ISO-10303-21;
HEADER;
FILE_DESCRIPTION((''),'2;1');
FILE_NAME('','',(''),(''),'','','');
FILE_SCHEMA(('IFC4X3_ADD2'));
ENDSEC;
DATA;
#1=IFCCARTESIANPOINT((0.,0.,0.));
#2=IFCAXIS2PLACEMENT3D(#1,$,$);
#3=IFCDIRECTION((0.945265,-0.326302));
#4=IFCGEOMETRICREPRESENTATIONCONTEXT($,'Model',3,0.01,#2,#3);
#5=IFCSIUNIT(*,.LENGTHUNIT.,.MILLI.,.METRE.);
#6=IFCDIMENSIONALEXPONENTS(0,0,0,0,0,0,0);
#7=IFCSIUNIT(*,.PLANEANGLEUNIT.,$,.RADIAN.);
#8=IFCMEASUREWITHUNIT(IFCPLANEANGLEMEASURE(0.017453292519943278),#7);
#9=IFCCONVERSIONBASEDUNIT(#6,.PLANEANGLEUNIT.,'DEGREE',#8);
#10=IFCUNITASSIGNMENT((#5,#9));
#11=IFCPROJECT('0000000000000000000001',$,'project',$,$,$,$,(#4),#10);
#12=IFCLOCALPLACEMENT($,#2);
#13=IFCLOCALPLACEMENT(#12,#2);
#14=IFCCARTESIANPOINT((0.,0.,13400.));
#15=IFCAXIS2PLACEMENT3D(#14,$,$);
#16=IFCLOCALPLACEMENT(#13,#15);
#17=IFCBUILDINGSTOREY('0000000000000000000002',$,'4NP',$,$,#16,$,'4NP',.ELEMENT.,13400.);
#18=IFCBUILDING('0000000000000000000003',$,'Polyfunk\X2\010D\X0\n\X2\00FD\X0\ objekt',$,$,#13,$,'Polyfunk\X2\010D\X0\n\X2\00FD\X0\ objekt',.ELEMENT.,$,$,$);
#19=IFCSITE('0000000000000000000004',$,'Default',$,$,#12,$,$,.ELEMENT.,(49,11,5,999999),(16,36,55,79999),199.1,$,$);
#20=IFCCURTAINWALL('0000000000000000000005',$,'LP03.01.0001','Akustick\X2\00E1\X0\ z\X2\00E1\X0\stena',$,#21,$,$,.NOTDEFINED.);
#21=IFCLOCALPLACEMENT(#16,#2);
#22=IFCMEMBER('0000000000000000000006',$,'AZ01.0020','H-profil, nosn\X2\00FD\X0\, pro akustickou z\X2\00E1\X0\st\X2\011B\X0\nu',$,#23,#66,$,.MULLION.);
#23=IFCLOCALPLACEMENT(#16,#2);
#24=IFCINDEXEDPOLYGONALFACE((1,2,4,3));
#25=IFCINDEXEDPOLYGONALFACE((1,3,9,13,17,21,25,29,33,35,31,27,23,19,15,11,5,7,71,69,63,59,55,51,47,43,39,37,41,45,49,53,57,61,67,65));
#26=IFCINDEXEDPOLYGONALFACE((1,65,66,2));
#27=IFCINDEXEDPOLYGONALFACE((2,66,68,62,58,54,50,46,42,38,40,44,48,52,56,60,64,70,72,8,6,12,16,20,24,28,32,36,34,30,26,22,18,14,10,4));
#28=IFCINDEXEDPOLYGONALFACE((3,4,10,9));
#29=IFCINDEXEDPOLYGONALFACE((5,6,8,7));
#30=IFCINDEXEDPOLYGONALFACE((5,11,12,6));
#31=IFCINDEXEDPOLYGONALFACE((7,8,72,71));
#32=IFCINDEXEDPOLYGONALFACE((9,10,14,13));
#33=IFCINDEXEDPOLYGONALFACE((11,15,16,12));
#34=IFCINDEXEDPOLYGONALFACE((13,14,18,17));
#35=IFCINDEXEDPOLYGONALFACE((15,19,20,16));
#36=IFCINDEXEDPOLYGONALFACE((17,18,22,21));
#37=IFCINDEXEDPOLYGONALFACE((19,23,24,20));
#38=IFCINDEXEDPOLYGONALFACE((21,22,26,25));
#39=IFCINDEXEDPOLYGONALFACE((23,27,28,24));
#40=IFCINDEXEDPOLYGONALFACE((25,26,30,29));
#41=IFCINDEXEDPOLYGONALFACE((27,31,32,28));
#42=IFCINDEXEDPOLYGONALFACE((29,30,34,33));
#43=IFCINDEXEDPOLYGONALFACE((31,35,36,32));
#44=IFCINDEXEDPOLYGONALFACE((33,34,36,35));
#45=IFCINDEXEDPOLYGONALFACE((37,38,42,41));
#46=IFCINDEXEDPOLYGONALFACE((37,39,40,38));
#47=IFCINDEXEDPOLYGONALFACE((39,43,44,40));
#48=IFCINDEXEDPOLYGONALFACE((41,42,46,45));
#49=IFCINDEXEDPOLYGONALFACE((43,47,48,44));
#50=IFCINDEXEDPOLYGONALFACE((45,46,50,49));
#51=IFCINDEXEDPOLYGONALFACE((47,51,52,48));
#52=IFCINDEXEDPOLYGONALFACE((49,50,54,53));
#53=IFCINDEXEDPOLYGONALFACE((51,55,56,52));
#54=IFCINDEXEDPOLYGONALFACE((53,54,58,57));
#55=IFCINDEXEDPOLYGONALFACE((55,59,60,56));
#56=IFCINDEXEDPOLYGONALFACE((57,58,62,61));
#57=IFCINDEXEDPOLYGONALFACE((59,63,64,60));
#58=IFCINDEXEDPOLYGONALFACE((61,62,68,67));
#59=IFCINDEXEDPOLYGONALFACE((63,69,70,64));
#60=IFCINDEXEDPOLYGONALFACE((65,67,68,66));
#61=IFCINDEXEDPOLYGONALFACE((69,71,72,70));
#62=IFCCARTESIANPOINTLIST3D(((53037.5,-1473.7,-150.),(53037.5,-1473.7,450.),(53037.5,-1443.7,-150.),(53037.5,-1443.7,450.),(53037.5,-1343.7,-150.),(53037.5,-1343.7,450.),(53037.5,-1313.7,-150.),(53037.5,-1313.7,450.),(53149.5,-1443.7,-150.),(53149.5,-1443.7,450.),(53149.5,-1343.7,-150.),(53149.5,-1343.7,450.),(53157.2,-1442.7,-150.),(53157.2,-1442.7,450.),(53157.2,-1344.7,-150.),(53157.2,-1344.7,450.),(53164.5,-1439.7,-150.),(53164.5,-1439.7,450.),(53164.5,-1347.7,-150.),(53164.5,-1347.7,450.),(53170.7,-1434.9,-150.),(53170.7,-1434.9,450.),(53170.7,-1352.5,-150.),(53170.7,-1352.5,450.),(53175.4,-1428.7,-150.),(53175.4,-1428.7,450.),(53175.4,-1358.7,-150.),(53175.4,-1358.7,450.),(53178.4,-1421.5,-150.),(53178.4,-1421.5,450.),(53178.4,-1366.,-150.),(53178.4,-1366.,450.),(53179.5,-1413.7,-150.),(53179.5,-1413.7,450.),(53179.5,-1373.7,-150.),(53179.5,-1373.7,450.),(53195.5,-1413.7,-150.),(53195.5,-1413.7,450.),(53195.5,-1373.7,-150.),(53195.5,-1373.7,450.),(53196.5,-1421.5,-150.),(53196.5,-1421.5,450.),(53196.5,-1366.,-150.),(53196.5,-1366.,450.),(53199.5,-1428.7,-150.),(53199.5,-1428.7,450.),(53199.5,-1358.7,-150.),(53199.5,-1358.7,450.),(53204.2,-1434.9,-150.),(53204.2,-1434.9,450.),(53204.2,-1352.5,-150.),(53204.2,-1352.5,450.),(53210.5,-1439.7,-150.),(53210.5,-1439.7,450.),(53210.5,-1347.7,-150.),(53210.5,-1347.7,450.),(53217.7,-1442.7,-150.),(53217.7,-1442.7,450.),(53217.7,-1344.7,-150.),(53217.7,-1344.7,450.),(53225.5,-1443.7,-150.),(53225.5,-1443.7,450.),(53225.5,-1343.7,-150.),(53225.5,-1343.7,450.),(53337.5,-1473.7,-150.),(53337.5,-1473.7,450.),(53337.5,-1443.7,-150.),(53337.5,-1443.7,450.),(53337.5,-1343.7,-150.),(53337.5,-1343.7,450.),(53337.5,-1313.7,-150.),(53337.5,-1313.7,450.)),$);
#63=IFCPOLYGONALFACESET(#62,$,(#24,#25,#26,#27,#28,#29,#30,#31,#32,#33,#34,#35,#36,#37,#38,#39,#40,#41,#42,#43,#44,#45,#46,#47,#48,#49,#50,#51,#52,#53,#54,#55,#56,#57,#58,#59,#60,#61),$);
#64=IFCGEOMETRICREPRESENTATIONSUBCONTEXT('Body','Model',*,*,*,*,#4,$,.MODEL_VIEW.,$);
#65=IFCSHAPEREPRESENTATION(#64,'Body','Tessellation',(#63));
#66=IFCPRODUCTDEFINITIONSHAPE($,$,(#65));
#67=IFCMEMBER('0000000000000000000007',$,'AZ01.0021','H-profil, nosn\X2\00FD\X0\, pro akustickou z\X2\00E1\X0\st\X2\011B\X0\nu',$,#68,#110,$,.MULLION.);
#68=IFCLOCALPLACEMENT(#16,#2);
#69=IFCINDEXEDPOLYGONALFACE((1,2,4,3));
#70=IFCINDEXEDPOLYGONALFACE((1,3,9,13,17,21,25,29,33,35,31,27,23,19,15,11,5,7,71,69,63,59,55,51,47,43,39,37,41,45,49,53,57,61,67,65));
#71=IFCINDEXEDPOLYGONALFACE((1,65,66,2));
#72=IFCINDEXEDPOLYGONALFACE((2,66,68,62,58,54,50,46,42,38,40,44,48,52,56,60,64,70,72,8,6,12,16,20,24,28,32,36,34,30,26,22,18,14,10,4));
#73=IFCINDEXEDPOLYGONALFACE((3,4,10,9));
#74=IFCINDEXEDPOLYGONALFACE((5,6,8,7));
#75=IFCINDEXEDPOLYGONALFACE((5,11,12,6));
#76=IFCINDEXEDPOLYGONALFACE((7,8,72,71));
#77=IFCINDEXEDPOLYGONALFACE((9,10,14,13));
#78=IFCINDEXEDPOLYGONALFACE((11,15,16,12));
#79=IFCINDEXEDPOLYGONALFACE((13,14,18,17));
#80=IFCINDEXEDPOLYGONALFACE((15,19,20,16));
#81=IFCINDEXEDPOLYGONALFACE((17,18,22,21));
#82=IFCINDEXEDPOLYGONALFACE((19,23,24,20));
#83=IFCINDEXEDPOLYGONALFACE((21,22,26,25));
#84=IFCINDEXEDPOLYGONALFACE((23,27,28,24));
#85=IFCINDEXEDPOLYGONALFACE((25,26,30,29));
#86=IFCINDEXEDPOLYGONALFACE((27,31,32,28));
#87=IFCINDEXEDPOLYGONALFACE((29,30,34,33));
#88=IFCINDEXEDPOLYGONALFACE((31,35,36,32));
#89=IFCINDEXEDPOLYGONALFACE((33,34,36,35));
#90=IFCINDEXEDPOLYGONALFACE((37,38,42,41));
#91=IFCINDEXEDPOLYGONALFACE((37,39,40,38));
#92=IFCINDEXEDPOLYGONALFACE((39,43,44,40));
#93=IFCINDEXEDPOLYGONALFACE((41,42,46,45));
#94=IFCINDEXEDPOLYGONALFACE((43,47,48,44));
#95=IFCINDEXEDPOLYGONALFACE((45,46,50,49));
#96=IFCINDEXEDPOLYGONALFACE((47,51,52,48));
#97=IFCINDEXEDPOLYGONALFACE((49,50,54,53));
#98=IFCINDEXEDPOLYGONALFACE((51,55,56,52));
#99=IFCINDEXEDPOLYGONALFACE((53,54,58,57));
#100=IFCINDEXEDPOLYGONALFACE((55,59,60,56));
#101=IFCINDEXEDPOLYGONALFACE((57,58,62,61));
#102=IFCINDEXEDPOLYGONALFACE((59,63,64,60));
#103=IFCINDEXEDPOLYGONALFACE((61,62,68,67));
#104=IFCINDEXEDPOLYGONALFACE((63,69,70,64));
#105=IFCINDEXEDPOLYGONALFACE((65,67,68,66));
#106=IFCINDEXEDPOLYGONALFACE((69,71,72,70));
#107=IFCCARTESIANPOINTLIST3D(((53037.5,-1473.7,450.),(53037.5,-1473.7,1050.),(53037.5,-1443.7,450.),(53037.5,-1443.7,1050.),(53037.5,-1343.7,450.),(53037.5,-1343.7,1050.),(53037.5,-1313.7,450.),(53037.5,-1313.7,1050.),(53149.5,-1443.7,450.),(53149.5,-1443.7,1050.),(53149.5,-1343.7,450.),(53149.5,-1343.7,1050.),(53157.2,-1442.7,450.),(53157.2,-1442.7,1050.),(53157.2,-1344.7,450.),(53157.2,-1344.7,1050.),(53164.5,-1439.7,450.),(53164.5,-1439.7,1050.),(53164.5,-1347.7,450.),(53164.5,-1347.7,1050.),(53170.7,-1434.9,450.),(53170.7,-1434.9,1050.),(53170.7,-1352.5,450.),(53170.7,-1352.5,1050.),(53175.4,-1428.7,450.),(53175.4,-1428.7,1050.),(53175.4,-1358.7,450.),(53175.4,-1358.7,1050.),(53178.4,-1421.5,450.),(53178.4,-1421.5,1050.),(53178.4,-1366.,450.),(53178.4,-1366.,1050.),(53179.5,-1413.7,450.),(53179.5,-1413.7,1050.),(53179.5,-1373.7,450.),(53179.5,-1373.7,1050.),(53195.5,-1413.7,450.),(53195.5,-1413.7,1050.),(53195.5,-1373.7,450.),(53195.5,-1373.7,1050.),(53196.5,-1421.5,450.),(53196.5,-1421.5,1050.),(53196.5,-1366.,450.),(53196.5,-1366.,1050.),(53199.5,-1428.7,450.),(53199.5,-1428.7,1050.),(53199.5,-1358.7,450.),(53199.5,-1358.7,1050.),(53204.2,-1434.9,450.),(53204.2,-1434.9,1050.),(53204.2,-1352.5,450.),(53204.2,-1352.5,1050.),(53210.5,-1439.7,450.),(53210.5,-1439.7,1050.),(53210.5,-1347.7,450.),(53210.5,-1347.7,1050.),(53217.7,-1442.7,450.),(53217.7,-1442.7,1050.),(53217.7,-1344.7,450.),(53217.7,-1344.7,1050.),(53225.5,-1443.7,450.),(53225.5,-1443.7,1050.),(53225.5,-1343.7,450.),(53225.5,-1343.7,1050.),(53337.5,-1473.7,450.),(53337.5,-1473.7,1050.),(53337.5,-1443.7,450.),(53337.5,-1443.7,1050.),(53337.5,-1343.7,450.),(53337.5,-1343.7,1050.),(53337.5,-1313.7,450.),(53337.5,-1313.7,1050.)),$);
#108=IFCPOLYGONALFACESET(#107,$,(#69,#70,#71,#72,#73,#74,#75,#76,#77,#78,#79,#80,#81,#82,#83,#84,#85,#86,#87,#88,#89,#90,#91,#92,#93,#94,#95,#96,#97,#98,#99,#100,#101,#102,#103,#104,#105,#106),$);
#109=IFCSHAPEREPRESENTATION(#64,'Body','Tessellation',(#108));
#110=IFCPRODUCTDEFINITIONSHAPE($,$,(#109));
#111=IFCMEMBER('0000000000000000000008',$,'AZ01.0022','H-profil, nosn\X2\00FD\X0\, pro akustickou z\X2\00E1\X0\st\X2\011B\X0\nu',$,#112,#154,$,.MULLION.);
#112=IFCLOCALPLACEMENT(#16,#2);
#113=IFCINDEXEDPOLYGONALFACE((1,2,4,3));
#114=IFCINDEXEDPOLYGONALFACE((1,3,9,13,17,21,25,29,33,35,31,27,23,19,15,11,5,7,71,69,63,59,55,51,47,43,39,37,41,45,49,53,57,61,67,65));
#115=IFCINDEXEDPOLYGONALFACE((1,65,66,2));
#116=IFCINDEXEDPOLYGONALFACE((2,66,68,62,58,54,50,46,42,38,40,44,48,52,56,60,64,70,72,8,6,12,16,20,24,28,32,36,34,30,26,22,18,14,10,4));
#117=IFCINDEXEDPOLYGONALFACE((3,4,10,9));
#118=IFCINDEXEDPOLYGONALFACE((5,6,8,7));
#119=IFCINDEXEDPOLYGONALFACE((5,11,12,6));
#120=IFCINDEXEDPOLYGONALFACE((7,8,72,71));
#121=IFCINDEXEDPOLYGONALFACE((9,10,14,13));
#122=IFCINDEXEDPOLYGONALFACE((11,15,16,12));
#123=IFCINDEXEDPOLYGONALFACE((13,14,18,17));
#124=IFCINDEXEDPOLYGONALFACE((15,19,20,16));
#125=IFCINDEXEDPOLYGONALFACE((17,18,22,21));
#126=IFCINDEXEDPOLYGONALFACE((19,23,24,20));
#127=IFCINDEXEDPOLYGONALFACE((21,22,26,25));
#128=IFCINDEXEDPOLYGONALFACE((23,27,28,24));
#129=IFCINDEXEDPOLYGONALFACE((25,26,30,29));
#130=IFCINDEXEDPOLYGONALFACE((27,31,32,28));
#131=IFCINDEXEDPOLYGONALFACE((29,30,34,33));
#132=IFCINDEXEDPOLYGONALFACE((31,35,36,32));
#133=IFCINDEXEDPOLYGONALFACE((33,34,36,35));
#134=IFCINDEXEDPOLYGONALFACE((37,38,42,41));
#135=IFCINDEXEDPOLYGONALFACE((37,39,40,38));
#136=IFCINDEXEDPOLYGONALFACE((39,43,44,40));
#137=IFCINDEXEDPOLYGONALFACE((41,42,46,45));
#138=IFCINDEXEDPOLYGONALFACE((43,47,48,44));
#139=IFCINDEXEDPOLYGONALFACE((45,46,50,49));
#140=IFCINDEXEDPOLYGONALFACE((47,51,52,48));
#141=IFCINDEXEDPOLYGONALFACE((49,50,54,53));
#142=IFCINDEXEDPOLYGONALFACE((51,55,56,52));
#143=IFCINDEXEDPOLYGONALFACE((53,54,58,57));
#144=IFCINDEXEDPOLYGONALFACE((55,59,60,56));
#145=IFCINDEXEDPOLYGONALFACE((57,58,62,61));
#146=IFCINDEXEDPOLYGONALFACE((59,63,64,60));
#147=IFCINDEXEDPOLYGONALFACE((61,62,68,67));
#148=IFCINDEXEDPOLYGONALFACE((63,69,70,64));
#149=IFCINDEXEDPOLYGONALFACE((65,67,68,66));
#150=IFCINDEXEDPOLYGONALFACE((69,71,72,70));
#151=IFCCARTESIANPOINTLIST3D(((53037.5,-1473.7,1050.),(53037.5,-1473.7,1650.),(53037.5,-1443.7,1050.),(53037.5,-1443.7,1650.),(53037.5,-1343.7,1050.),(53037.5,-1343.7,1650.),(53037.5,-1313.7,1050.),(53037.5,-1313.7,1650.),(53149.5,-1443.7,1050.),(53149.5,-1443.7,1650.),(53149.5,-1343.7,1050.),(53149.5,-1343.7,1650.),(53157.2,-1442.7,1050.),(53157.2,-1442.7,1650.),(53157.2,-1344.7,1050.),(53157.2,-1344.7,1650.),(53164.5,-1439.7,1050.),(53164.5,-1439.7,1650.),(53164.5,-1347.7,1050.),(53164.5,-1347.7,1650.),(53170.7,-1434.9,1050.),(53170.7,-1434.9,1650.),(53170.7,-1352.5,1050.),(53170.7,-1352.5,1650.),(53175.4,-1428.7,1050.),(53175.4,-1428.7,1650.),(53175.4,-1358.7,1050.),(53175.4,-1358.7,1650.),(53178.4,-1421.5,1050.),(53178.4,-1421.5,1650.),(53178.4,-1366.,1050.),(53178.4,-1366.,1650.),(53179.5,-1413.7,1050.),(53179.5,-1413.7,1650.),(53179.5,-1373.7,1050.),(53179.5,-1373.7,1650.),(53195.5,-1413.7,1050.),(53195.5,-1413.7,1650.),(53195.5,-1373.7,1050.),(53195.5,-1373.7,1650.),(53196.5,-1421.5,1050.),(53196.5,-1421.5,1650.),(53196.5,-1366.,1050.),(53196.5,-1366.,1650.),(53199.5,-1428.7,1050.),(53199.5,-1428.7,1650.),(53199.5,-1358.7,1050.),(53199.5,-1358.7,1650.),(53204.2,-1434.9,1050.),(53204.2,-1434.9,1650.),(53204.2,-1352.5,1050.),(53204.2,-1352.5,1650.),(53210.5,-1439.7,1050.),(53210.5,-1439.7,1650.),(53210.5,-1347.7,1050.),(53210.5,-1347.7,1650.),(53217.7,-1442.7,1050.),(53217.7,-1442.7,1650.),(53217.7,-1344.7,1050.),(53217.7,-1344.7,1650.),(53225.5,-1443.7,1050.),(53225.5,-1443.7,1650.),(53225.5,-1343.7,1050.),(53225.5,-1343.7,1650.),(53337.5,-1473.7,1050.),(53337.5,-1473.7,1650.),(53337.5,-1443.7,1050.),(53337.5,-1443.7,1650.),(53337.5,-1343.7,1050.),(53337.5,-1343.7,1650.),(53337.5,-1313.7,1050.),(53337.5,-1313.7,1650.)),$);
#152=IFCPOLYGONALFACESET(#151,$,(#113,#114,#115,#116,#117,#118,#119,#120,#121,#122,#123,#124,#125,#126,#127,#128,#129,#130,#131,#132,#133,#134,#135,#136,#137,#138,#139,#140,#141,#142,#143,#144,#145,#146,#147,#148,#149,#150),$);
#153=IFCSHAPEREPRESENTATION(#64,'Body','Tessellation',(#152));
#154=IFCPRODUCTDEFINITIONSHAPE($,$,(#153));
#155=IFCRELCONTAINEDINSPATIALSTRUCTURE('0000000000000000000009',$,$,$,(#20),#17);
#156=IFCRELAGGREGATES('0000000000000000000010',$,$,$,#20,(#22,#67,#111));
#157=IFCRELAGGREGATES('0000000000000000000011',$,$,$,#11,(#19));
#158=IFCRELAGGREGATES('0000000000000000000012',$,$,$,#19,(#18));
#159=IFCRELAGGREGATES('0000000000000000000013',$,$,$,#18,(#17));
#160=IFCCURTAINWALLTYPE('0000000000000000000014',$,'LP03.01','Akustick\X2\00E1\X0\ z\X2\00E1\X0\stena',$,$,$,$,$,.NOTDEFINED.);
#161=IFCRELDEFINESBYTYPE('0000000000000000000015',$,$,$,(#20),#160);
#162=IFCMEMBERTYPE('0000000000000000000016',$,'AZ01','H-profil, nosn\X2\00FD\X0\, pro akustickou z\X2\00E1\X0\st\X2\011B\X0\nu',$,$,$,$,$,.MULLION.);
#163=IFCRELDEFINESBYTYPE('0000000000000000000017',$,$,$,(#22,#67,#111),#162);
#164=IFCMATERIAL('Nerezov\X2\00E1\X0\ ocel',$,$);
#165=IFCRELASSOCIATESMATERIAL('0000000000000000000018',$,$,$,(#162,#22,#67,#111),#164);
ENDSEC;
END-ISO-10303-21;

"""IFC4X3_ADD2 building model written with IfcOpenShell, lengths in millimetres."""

from ifc_helpers import new_model, entity, si_unit, converted_unit, direction, frame, frame_2d, origin, place, context, subcontext, project, spatial, polyline, circle_curve, parameter, trimmed, segment, composite_curve, outline, extrude, source, transform, mapped, material, material_profile, profile_set, profile_usage, type_object, element, aggregate, save


model = new_model("IFC4X3_ADD2")

# Units and contexts
model_context = context("Model", 3, precision=0.01, world=origin(), true_north=direction((0.945265, -0.326302)))
body_context = subcontext(model_context, "Body", "Model", "MODEL_VIEW")
ifc_project = project(units=[si_unit("LENGTHUNIT", "METRE", prefix="MILLI"), converted_unit("PLANEANGLEUNIT", "DEGREE", entity("IfcPlaneAngleMeasure", 0.017453292519943278), si_unit("PLANEANGLEUNIT", "RADIAN"), dimensions=[0, 0, 0, 0, 0, 0, 0])], contexts=[model_context])

# Site, building, storey
site_placement = place(None, origin())
site = spatial("IfcSite", under=ifc_project, at=site_placement, Name="Default", CompositionType="ELEMENT", RefLatitude=(49, 11, 5, 999999), RefLongitude=(16, 36, 55, 79999), RefElevation=199.1)
building_placement = place(site_placement, origin())
building = spatial("IfcBuilding", under=site, at=building_placement, Name="Polyfunkčný objekt", LongName="Polyfunkčný objekt", CompositionType="ELEMENT")
storey_placement = place(building_placement, frame((0.0, 0.0, 13400.0)))
storey = spatial("IfcBuildingStorey", under=building, at=storey_placement, Name="4NP", LongName="4NP", CompositionType="ELEMENT", Elevation=13400.0)

# Curtain wall, members
curtain_wall_type_1 = type_object("IfcCurtainWallType", Name="LP03.01", Description="Akustická zástena", PredefinedType="NOTDEFINED")
curtain_wall_1_placement = place(storey_placement, frame((0.0, 0.0, -13400.0)))
curtain_wall_1 = element("IfcCurtainWall", 1, at=curtain_wall_1_placement, inside=storey, type_object=curtain_wall_type_1, Name="LP03.01.0001", Description="Akustická zástena", PredefinedType="NOTDEFINED")
ifc_material_1 = material(Name="Nerezová ocel")
ifc_material_profile = material_profile(ifc_material_1, outline(composite_curve([segment(polyline([(50.0, -150.0), (80.0, -150.0)]), True, "CONTINUOUS"), segment(polyline([(80.0, -150.0), (80.0, 150.0)]), True, "CONTINUOUS"), segment(polyline([(80.0, 150.0), (50.0, 150.0)]), True, "CONTINUOUS"), segment(polyline([(50.0, 150.0), (50.0, 38.0)]), True, "CONTINUOUS"), segment(trimmed(circle_curve(frame_2d((20.0, 38.0), x_axis=(0.0, 1.0)), 30.0), [parameter(180.0)], [parameter(270.0)], True, "PARAMETER"), False, "CONTINUOUS"), segment(polyline([(20.0, 8.0), (-20.0, 8.0)]), True, "CONTINUOUS"), segment(trimmed(circle_curve(frame_2d((-20.0, 38.0), x_axis=(0.0, 1.0)), 30.0), [parameter(90.0)], [parameter(180.0)], True, "PARAMETER"), False, "CONTINUOUS"), segment(polyline([(-50.0, 38.0), (-50.0, 150.0)]), True, "CONTINUOUS"), segment(polyline([(-50.0, 150.0), (-80.0, 150.0)]), True, "CONTINUOUS"), segment(polyline([(-80.0, 150.0), (-80.0, -150.0)]), True, "CONTINUOUS"), segment(polyline([(-80.0, -150.0), (-50.0, -150.0)]), True, "CONTINUOUS"), segment(polyline([(-50.0, -150.0), (-50.0, -38.0)]), True, "CONTINUOUS"), segment(trimmed(circle_curve(frame_2d((-20.0, -38.0), x_axis=(0.0, 1.0)), 30.0), [parameter(0.0)], [parameter(90.0)], True, "PARAMETER"), False, "CONTINUOUS"), segment(polyline([(-20.0, -8.0), (20.0, -8.0)]), True, "CONTINUOUS"), segment(trimmed(circle_curve(frame_2d((20.0, -38.0), x_axis=(0.0, 1.0)), 30.0), [parameter(270.0)], [parameter(0.0)], True, "PARAMETER"), False, "CONTINUOUS"), segment(polyline([(50.0, -38.0), (50.0, -150.0)]), True, "CONTINUOUS")], self_intersect=False)), Name="Profil zástena")
ifc_profile_set = profile_set([ifc_material_profile], Name="Profil zástena")
ifc_profile_usage = profile_usage(ifc_profile_set)
member_type = type_object("IfcMemberType", Name="AZ01", Description="H-profil, nosný, pro akustickou zástěnu", PredefinedType="MULLION", material=ifc_profile_set)
shared_shape_1 = source(origin(), body_context, "Body", "SweptSolid", [
    extrude(outline(composite_curve([segment(polyline([(50.0, -150.0), (80.0, -150.0)]), True, "CONTINUOUS"), segment(polyline([(80.0, -150.0), (80.0, 150.0)]), True, "CONTINUOUS"), segment(polyline([(80.0, 150.0), (50.0, 150.0)]), True, "CONTINUOUS"), segment(polyline([(50.0, 150.0), (50.0, 38.0)]), True, "CONTINUOUS"), segment(trimmed(circle_curve(frame_2d((20.0, 38.0), x_axis=(0.0, 1.0)), 30.0), [parameter(180.0)], [parameter(270.0)], True, "PARAMETER"), False, "CONTINUOUS"), segment(polyline([(20.0, 8.0), (-20.0, 8.0)]), True, "CONTINUOUS"), segment(trimmed(circle_curve(frame_2d((-20.0, 38.0), x_axis=(0.0, 1.0)), 30.0), [parameter(90.0)], [parameter(180.0)], True, "PARAMETER"), False, "CONTINUOUS"), segment(polyline([(-50.0, 38.0), (-50.0, 150.0)]), True, "CONTINUOUS"), segment(polyline([(-50.0, 150.0), (-80.0, 150.0)]), True, "CONTINUOUS"), segment(polyline([(-80.0, 150.0), (-80.0, -150.0)]), True, "CONTINUOUS"), segment(polyline([(-80.0, -150.0), (-50.0, -150.0)]), True, "CONTINUOUS"), segment(polyline([(-50.0, -150.0), (-50.0, -38.0)]), True, "CONTINUOUS"), segment(trimmed(circle_curve(frame_2d((-20.0, -38.0), x_axis=(0.0, 1.0)), 30.0), [parameter(0.0)], [parameter(90.0)], True, "PARAMETER"), False, "CONTINUOUS"), segment(polyline([(-20.0, -8.0), (20.0, -8.0)]), True, "CONTINUOUS"), segment(trimmed(circle_curve(frame_2d((20.0, -38.0), x_axis=(0.0, 1.0)), 30.0), [parameter(270.0)], [parameter(0.0)], True, "PARAMETER"), False, "CONTINUOUS"), segment(polyline([(50.0, -38.0), (50.0, -150.0)]), True, "CONTINUOUS")], self_intersect=False)), frame((0.0, 0.0, -600.0), z_axis=(0.0, 0.0, 1.0), x_axis=(0.0, -1.0, 0.0)), (0.0, 0.0, 1.0), 600.0),
])
member_1_placement = place(curtain_wall_1_placement, frame((53187.5, -1393.7, 13250.0), z_axis=(0.0, 0.0, -1.0), x_axis=(1.0, 0.0, 0.0)))
member_1 = element("IfcMember", 2, at=member_1_placement, type_object=member_type, material=ifc_profile_usage, Name="AZ01.0020", Description="H-profil, nosný, pro akustickou zástěnu", PredefinedType="MULLION", context=body_context, shape_type="MappedRepresentation", body=[
    mapped(shared_shape_1, transform((0.0, 0.0, 0.0), scale=1.0)),
])
shared_shape_2 = source(origin(), body_context, "Body", "SweptSolid", [
    extrude(outline(composite_curve([segment(polyline([(50.0, -150.0), (80.0, -150.0)]), True, "CONTINUOUS"), segment(polyline([(80.0, -150.0), (80.0, 150.0)]), True, "CONTINUOUS"), segment(polyline([(80.0, 150.0), (50.0, 150.0)]), True, "CONTINUOUS"), segment(polyline([(50.0, 150.0), (50.0, 38.0)]), True, "CONTINUOUS"), segment(trimmed(circle_curve(frame_2d((20.0, 38.0), x_axis=(0.0, 1.0)), 30.0), [parameter(180.0)], [parameter(270.0)], True, "PARAMETER"), False, "CONTINUOUS"), segment(polyline([(20.0, 8.0), (-20.0, 8.0)]), True, "CONTINUOUS"), segment(trimmed(circle_curve(frame_2d((-20.0, 38.0), x_axis=(0.0, 1.0)), 30.0), [parameter(90.0)], [parameter(180.0)], True, "PARAMETER"), False, "CONTINUOUS"), segment(polyline([(-50.0, 38.0), (-50.0, 150.0)]), True, "CONTINUOUS"), segment(polyline([(-50.0, 150.0), (-80.0, 150.0)]), True, "CONTINUOUS"), segment(polyline([(-80.0, 150.0), (-80.0, -150.0)]), True, "CONTINUOUS"), segment(polyline([(-80.0, -150.0), (-50.0, -150.0)]), True, "CONTINUOUS"), segment(polyline([(-50.0, -150.0), (-50.0, -38.0)]), True, "CONTINUOUS"), segment(trimmed(circle_curve(frame_2d((-20.0, -38.0), x_axis=(0.0, 1.0)), 30.0), [parameter(0.0)], [parameter(90.0)], True, "PARAMETER"), False, "CONTINUOUS"), segment(polyline([(-20.0, -8.0), (20.0, -8.0)]), True, "CONTINUOUS"), segment(trimmed(circle_curve(frame_2d((20.0, -38.0), x_axis=(0.0, 1.0)), 30.0), [parameter(270.0)], [parameter(0.0)], True, "PARAMETER"), False, "CONTINUOUS"), segment(polyline([(50.0, -38.0), (50.0, -150.0)]), True, "CONTINUOUS")], self_intersect=False)), frame((0.0, 0.0, -600.0), z_axis=(0.0, 0.0, 1.0), x_axis=(0.0, -1.0, 0.0)), (0.0, 0.0, 1.0), 600.0),
])
member_2_placement = place(curtain_wall_1_placement, frame((53187.5, -1393.7, 13850.0), z_axis=(0.0, 0.0, -1.0), x_axis=(1.0, 0.0, 0.0)))
member_2 = element("IfcMember", 3, at=member_2_placement, type_object=member_type, material=ifc_profile_usage, Name="AZ01.0021", Description="H-profil, nosný, pro akustickou zástěnu", PredefinedType="MULLION", context=body_context, shape_type="MappedRepresentation", body=[
    mapped(shared_shape_2, transform((0.0, 0.0, 0.0), scale=1.0)),
])
member_3_placement = place(curtain_wall_1_placement, frame((53187.5, -1393.7, 14450.0), z_axis=(0.0, 0.0, -1.0), x_axis=(1.0, 0.0, 0.0)))
member_3 = element("IfcMember", 4, at=member_3_placement, type_object=member_type, material=ifc_profile_usage, Name="AZ01.0022", Description="H-profil, nosný, pro akustickou zástěnu", PredefinedType="MULLION", context=body_context, shape_type="MappedRepresentation", body=[
    mapped(shared_shape_2, transform((0.0, 0.0, 0.0), scale=1.0)),
])

aggregate(curtain_wall_1, [member_1, member_2, member_3])

save(model, "model.ifc")
